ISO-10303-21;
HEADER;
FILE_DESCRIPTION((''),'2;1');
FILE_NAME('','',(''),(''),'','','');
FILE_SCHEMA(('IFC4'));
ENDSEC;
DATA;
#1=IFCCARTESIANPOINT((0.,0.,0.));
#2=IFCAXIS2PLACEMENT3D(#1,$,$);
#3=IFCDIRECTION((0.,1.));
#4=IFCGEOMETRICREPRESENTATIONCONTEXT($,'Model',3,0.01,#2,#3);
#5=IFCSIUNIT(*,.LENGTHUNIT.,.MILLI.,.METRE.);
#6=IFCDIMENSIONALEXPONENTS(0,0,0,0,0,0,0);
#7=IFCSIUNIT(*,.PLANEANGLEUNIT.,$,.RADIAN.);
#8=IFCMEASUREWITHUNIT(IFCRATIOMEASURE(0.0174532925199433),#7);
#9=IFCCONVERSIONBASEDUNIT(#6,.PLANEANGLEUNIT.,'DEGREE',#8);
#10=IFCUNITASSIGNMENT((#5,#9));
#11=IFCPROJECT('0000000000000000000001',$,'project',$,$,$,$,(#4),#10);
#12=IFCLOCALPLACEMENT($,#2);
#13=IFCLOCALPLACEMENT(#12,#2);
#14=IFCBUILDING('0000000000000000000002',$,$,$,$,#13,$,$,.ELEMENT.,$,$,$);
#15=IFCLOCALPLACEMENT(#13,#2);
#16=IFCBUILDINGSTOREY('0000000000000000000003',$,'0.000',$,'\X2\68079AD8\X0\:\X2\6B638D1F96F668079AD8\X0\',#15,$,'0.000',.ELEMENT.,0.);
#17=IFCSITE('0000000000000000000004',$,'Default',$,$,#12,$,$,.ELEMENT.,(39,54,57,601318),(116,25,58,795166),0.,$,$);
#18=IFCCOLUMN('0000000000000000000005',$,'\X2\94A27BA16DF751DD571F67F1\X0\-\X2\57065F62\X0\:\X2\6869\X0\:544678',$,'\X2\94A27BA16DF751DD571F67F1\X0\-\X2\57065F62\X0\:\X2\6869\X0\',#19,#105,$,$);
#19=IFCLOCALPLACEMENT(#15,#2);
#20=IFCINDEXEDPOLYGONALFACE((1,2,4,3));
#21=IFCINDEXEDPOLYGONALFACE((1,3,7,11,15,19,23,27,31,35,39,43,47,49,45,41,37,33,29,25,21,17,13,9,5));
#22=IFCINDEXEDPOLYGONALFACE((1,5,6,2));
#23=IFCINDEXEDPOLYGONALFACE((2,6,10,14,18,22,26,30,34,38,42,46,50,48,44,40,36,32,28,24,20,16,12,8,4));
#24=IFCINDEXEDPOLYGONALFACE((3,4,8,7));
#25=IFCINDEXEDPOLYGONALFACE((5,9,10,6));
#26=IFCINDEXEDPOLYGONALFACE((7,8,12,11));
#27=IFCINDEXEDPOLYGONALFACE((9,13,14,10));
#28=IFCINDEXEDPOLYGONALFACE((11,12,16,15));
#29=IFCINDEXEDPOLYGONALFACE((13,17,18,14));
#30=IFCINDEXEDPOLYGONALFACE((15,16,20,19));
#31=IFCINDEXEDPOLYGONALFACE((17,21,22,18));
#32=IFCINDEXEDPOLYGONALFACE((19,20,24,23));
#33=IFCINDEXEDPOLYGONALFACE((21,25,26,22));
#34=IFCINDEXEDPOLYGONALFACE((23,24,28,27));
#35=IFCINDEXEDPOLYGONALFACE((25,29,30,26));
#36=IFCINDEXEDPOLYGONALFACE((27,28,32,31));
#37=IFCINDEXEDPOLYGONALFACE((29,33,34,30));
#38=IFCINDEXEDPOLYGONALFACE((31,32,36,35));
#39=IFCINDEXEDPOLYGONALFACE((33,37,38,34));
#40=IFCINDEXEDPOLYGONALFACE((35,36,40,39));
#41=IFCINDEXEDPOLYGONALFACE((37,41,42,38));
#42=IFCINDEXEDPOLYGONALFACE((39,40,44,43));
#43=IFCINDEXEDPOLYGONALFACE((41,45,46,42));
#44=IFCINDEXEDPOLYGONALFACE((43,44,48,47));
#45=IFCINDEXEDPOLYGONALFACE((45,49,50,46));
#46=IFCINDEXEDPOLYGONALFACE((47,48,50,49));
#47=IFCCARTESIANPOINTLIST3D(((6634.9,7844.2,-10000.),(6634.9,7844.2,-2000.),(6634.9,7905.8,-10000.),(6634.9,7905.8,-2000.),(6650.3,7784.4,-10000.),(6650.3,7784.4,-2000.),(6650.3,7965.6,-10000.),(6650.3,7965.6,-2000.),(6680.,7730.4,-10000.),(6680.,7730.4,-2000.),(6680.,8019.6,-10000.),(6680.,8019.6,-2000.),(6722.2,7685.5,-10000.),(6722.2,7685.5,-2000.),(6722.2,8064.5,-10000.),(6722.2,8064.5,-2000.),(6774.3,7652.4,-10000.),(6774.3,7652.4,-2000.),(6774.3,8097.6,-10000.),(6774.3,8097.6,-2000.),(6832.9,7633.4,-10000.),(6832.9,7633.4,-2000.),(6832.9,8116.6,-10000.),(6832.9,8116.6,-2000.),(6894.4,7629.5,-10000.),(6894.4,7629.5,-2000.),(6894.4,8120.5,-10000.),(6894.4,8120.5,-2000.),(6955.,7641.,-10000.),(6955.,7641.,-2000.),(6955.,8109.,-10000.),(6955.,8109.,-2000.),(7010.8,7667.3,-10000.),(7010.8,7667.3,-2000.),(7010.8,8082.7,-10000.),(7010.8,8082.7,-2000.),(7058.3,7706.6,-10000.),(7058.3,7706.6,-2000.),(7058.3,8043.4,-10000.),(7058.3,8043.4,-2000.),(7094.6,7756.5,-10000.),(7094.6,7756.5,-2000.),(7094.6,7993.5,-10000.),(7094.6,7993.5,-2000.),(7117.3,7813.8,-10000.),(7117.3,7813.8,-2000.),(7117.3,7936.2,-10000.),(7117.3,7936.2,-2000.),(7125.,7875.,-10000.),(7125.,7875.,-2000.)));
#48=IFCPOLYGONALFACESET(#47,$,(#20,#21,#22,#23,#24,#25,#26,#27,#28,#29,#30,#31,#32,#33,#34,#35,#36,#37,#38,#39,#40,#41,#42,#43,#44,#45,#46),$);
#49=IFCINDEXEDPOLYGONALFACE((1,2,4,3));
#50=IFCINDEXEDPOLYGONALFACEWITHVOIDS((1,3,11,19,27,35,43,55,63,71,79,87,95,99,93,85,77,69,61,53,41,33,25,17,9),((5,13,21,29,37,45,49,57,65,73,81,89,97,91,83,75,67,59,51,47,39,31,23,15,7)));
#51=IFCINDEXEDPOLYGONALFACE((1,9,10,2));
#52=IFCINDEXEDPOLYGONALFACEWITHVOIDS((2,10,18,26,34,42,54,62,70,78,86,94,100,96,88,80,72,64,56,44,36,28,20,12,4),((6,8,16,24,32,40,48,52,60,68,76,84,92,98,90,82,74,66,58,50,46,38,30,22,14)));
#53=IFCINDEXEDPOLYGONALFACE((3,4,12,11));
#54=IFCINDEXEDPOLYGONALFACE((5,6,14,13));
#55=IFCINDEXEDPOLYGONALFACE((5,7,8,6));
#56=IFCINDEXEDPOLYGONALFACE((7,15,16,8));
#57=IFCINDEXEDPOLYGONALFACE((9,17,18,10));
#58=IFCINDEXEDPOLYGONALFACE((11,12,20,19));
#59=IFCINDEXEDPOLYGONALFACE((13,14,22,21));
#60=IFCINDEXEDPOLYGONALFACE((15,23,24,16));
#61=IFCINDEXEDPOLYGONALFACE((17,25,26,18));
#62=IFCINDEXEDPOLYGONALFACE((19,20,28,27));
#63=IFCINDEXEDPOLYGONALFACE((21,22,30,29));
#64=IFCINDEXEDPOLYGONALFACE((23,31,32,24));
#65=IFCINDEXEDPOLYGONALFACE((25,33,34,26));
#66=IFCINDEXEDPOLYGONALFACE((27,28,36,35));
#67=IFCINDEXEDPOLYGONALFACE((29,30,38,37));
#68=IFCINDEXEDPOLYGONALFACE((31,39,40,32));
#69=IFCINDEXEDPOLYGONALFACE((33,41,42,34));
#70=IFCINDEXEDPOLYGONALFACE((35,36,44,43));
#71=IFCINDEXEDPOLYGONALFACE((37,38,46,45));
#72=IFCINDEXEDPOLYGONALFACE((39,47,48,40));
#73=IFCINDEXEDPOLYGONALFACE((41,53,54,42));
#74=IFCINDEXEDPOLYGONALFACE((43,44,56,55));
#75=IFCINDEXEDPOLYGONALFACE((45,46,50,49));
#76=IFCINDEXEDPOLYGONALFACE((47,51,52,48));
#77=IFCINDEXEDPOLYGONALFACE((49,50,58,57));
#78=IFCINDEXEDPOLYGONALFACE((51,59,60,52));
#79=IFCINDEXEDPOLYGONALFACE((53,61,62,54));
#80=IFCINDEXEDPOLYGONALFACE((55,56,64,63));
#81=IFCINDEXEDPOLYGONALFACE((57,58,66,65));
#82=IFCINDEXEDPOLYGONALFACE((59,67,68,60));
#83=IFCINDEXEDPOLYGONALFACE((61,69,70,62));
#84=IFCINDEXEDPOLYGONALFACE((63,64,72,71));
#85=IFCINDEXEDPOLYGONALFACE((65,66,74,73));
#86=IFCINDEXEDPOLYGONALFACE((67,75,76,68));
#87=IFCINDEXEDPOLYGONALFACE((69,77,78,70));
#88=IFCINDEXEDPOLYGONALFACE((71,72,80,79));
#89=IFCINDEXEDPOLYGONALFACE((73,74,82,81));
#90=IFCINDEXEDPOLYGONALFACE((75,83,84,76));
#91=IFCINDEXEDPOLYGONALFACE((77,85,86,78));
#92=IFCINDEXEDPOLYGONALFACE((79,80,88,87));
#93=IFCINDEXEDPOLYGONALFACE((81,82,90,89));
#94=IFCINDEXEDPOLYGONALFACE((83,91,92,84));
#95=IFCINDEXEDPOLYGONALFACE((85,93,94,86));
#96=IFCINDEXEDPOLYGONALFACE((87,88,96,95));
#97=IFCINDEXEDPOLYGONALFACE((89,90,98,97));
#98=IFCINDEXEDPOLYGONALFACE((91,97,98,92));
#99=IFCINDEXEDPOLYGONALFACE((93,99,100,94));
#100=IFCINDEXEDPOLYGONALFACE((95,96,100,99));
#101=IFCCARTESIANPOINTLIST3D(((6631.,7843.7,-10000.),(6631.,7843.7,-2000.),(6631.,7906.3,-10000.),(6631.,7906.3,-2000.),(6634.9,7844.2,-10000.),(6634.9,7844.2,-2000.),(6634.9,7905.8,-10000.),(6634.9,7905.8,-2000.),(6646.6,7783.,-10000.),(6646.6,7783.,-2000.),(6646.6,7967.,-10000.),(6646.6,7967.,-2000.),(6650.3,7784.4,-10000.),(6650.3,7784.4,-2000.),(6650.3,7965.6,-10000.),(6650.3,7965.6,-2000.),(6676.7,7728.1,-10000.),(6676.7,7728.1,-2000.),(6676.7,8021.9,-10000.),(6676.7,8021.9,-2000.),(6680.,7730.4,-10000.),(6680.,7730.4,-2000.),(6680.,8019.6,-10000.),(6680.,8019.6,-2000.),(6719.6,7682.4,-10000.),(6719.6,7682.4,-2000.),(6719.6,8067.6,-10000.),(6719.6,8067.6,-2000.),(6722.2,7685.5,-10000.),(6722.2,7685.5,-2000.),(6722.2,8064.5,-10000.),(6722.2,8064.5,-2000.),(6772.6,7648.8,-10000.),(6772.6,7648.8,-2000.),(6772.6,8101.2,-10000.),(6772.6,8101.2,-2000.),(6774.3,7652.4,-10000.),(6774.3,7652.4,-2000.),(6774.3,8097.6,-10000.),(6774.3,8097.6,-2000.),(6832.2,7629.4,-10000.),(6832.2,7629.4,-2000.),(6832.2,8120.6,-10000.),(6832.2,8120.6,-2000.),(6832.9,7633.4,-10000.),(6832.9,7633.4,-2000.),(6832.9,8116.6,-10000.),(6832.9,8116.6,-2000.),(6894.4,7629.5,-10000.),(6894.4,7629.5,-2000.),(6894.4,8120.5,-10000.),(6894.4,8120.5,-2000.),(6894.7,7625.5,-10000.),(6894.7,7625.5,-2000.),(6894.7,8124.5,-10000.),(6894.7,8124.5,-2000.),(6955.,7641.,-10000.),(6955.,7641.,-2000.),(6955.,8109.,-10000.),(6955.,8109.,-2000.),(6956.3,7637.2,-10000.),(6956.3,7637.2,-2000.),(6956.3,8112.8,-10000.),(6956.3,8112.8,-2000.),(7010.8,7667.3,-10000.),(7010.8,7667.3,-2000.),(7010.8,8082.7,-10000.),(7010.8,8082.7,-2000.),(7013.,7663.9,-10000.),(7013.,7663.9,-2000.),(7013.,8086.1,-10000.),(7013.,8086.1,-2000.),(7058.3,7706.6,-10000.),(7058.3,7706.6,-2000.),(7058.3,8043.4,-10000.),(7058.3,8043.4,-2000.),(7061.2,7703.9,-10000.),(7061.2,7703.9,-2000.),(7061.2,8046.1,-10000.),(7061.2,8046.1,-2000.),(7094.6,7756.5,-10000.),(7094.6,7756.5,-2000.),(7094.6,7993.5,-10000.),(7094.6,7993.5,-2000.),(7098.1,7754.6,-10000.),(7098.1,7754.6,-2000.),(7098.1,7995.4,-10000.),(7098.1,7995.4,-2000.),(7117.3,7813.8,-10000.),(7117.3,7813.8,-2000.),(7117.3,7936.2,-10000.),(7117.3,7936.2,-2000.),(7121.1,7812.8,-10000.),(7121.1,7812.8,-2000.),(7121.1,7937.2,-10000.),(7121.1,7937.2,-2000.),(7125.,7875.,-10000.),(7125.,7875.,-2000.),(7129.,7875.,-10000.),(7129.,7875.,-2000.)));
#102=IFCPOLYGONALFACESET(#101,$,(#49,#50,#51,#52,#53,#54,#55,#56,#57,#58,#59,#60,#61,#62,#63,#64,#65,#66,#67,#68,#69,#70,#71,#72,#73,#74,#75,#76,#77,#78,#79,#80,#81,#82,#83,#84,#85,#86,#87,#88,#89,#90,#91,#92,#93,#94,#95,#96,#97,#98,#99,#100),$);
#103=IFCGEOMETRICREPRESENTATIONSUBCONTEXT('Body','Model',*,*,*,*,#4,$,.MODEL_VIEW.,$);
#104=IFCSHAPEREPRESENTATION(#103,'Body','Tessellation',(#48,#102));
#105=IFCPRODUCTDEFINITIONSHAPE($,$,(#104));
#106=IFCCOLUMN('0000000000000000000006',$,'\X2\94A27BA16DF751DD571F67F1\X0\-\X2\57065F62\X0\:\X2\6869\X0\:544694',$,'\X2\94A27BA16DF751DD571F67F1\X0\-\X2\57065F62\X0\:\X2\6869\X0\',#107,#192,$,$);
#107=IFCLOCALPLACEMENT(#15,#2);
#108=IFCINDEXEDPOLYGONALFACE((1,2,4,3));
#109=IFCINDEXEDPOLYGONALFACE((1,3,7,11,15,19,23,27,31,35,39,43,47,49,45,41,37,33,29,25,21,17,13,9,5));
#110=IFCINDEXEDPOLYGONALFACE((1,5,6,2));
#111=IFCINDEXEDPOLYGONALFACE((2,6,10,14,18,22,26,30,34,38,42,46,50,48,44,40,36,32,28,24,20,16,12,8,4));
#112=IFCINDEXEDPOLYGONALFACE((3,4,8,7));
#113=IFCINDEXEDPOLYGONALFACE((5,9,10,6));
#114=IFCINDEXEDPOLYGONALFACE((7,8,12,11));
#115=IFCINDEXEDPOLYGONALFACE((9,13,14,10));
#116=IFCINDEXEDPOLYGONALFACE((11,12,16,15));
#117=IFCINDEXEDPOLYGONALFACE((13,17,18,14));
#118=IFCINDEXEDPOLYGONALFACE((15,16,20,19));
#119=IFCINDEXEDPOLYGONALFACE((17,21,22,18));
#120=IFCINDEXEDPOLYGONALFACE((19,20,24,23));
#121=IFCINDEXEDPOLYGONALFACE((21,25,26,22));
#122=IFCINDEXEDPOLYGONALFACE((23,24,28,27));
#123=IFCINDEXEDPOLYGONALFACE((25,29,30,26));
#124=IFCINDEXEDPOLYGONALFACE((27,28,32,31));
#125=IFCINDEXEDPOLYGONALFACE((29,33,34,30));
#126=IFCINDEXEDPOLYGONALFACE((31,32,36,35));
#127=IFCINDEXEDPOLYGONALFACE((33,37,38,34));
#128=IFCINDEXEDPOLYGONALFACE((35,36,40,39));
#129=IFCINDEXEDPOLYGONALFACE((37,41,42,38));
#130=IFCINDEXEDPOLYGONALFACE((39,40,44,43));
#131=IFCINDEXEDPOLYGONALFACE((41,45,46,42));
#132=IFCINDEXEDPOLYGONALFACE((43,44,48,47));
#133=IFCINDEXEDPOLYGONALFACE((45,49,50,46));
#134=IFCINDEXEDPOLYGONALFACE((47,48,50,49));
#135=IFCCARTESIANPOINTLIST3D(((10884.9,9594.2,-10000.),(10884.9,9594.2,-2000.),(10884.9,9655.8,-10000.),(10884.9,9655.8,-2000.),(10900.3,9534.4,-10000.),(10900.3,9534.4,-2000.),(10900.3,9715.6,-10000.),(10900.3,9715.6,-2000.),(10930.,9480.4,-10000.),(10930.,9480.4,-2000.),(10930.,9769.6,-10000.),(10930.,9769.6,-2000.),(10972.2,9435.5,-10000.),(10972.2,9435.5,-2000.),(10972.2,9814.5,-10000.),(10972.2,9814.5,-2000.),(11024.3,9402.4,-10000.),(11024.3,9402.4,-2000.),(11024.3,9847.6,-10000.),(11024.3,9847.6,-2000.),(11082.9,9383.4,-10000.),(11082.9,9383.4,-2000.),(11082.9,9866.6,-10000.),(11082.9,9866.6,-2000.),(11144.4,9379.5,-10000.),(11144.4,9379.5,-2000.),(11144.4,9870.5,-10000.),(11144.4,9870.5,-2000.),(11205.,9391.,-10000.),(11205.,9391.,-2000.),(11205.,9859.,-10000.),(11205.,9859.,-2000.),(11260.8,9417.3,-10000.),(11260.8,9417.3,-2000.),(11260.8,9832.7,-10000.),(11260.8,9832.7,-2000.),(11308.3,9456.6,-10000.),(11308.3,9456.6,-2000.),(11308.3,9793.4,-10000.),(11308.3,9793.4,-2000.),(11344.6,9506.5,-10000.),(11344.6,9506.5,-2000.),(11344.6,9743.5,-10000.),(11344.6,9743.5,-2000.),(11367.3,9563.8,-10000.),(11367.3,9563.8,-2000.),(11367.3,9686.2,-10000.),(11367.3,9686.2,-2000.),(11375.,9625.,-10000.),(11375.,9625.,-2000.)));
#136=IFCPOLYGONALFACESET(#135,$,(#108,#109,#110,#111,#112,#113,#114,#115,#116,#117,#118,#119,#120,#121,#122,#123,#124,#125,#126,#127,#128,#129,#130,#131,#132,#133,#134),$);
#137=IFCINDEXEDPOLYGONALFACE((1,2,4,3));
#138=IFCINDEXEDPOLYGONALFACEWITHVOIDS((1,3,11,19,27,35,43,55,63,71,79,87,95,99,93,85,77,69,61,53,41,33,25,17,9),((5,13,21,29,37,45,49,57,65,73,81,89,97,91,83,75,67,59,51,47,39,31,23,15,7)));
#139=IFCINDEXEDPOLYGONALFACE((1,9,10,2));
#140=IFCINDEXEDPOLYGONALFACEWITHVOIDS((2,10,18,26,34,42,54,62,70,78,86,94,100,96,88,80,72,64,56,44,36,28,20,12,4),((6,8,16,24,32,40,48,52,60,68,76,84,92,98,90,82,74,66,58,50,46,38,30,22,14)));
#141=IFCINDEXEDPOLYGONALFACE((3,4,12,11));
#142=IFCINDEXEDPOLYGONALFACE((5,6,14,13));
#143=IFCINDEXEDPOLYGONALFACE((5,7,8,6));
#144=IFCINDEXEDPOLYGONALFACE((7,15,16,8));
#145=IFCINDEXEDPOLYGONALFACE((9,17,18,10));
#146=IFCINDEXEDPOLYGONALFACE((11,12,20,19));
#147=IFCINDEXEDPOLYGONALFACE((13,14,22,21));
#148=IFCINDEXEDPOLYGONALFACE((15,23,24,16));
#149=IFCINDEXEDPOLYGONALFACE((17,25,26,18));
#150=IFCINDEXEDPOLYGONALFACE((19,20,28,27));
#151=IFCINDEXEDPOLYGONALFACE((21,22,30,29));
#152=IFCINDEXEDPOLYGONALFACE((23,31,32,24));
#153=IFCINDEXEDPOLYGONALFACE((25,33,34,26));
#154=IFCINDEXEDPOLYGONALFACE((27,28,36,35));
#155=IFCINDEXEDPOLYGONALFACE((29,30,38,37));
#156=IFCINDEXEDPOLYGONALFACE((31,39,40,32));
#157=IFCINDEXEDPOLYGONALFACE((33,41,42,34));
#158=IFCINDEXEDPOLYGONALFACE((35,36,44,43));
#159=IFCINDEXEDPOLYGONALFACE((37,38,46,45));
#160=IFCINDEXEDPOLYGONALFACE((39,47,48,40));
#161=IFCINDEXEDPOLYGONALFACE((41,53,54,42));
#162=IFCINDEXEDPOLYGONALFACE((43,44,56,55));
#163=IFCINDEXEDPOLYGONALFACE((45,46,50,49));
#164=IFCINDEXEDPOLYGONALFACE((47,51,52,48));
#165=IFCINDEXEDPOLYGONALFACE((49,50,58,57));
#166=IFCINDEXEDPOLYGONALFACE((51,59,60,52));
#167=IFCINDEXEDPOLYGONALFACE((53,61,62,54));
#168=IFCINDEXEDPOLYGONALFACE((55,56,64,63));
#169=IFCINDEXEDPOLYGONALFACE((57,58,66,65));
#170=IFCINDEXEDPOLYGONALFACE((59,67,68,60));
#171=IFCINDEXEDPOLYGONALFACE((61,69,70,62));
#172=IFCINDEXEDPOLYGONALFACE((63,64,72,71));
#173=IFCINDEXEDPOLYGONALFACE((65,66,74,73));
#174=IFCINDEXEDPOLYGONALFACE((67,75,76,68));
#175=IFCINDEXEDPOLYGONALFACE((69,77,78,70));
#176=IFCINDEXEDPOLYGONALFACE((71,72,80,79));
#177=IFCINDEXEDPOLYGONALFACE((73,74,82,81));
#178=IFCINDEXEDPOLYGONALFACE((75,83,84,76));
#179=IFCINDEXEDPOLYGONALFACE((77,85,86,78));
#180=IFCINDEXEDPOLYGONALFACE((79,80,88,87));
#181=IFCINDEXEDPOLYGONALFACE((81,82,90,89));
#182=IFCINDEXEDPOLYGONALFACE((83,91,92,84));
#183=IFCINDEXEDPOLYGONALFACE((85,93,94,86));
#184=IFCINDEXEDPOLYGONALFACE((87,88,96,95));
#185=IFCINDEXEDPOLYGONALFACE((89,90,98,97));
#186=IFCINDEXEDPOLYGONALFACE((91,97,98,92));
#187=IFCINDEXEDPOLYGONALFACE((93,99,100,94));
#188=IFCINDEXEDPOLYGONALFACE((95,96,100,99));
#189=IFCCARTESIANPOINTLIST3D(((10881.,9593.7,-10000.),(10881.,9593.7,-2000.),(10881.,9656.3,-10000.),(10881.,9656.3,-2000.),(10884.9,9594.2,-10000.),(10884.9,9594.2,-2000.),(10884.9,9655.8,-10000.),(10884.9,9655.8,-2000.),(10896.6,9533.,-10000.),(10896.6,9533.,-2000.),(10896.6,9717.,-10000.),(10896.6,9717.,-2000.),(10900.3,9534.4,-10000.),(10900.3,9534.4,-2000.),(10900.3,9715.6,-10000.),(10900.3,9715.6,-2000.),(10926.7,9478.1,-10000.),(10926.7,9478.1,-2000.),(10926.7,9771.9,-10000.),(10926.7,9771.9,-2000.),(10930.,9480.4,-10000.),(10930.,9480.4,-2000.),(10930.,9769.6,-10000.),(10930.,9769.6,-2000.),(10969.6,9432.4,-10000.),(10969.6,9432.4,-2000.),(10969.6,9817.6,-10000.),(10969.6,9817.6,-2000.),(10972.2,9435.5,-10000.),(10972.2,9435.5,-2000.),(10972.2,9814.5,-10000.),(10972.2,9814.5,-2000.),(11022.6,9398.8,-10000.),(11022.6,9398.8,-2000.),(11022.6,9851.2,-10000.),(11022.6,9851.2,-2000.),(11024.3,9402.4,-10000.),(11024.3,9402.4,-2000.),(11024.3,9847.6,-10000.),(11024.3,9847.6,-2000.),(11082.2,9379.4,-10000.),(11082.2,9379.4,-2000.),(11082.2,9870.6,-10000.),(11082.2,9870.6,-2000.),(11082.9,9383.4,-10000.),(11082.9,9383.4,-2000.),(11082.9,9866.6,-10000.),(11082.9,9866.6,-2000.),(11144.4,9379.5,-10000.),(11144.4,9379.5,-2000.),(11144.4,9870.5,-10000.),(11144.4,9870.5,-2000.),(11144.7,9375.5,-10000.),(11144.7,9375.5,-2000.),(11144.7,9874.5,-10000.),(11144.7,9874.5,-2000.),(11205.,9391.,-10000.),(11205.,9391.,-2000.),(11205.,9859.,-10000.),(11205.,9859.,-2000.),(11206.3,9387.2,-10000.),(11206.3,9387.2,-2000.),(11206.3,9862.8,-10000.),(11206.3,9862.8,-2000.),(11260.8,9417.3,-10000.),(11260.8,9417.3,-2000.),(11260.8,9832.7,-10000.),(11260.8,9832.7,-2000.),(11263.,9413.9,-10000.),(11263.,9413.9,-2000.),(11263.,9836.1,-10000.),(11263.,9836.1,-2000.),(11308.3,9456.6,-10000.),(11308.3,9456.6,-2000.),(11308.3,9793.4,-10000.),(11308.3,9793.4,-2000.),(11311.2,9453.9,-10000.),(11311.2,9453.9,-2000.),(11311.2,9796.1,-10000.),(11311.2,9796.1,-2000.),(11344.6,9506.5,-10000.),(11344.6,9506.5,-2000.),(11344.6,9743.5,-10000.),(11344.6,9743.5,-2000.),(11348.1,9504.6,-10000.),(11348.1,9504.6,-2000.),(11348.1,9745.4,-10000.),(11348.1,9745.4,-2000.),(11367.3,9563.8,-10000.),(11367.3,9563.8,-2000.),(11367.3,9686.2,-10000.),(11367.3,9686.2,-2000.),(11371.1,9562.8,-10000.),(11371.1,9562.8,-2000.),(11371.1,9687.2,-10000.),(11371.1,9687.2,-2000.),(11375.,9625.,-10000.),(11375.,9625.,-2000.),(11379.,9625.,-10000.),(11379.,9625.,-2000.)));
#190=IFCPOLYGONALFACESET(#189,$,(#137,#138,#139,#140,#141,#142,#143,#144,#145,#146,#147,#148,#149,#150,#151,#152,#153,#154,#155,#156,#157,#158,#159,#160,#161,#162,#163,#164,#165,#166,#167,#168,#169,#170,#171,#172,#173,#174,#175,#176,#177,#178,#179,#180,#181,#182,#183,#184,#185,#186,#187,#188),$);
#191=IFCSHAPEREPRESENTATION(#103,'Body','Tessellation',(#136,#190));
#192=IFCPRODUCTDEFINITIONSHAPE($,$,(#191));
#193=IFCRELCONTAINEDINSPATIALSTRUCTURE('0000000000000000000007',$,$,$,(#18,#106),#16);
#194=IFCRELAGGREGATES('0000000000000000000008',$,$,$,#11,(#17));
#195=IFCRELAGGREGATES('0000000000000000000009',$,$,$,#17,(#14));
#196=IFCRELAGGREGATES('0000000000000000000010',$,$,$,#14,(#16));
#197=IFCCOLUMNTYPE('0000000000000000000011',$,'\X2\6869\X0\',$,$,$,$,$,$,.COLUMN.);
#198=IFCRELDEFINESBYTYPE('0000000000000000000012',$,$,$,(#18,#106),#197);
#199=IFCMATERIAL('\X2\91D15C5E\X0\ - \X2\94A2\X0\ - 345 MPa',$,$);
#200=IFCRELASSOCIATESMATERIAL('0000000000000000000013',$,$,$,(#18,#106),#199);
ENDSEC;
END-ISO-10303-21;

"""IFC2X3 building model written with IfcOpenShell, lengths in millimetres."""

from ifc_helpers import new_model, entity, si_unit, converted_unit, direction, frame, frame_2d, origin, place, context, subcontext, project, spatial, circle, hollow_circle, extrude, source, transform, mapped, material, type_object, type_shapes, element, save


model = new_model("IFC2X3")

# Units and contexts
model_context = context("Model", 3, precision=0.01, world=origin(), true_north=direction((0.0, 1.0)))
body_context = subcontext(model_context, "Body", "Model", "MODEL_VIEW")
ifc_project = project(units=[si_unit("LENGTHUNIT", "METRE", prefix="MILLI"), converted_unit("PLANEANGLEUNIT", "DEGREE", entity("IfcRatioMeasure", 0.0174532925199433), si_unit("PLANEANGLEUNIT", "RADIAN"), dimensions=[0, 0, 0, 0, 0, 0, 0])], contexts=[model_context])

# Site, building, storey
site_placement = place(None, origin())
site = spatial("IfcSite", under=ifc_project, at=site_placement, Name="Default", CompositionType="ELEMENT", RefLatitude=(39, 54, 57, 601318), RefLongitude=(116, 25, 58, 795166), RefElevation=0.0)
building_placement = place(site_placement, origin())
building = spatial("IfcBuilding", under=site, at=building_placement, CompositionType="ELEMENT")
storey_placement = place(building_placement, origin())
storey = spatial("IfcBuildingStorey", under=building, at=storey_placement, Name="0.000", ObjectType="标高:正负零标高", LongName="0.000", CompositionType="ELEMENT", Elevation=0.0)

# Columns
ifc_material_1 = material(Name="金属 - 钢 - 345 MPa")
column_type = type_object("IfcColumnType", Name="桩", PredefinedType="COLUMN")
shared_shape = source(origin(), body_context, "Body", "SweptSolid", [
    extrude(circle(Radius=246.0, at=frame_2d((0.0, 0.0), x_axis=(1.0, 0.0))), frame((0.0, 0.0, -10000.0)), (0.0, 0.0, 1.0), 8000.0),
    extrude(hollow_circle(Radius=250.0, WallThickness=4.0, at=frame_2d((0.0, 0.0), x_axis=(1.0, 0.0))), frame((0.0, 0.0, -10000.0)), (0.0, 0.0, 1.0), 8000.0),
])
type_shapes(column_type, [shared_shape])
for number, where, name in (
    (1, (6879.0, 7875.0, 0.0), "钢管混凝土柱-圆形:桩:544678"),
    (2, (11129.0, 9625.0, 0.0), "钢管混凝土柱-圆形:桩:544694"),
):
    element("IfcColumn", number, at=place(storey_placement, frame(where)), inside=storey, type_object=column_type, material=ifc_material_1, Name=name, ObjectType="钢管混凝土柱-圆形:桩", context=body_context, shape_type="MappedRepresentation", body=[
        mapped(shared_shape, transform((0.0, 0.0, 0.0), scale=1.0)),
    ])

save(model, "model.ifc")
